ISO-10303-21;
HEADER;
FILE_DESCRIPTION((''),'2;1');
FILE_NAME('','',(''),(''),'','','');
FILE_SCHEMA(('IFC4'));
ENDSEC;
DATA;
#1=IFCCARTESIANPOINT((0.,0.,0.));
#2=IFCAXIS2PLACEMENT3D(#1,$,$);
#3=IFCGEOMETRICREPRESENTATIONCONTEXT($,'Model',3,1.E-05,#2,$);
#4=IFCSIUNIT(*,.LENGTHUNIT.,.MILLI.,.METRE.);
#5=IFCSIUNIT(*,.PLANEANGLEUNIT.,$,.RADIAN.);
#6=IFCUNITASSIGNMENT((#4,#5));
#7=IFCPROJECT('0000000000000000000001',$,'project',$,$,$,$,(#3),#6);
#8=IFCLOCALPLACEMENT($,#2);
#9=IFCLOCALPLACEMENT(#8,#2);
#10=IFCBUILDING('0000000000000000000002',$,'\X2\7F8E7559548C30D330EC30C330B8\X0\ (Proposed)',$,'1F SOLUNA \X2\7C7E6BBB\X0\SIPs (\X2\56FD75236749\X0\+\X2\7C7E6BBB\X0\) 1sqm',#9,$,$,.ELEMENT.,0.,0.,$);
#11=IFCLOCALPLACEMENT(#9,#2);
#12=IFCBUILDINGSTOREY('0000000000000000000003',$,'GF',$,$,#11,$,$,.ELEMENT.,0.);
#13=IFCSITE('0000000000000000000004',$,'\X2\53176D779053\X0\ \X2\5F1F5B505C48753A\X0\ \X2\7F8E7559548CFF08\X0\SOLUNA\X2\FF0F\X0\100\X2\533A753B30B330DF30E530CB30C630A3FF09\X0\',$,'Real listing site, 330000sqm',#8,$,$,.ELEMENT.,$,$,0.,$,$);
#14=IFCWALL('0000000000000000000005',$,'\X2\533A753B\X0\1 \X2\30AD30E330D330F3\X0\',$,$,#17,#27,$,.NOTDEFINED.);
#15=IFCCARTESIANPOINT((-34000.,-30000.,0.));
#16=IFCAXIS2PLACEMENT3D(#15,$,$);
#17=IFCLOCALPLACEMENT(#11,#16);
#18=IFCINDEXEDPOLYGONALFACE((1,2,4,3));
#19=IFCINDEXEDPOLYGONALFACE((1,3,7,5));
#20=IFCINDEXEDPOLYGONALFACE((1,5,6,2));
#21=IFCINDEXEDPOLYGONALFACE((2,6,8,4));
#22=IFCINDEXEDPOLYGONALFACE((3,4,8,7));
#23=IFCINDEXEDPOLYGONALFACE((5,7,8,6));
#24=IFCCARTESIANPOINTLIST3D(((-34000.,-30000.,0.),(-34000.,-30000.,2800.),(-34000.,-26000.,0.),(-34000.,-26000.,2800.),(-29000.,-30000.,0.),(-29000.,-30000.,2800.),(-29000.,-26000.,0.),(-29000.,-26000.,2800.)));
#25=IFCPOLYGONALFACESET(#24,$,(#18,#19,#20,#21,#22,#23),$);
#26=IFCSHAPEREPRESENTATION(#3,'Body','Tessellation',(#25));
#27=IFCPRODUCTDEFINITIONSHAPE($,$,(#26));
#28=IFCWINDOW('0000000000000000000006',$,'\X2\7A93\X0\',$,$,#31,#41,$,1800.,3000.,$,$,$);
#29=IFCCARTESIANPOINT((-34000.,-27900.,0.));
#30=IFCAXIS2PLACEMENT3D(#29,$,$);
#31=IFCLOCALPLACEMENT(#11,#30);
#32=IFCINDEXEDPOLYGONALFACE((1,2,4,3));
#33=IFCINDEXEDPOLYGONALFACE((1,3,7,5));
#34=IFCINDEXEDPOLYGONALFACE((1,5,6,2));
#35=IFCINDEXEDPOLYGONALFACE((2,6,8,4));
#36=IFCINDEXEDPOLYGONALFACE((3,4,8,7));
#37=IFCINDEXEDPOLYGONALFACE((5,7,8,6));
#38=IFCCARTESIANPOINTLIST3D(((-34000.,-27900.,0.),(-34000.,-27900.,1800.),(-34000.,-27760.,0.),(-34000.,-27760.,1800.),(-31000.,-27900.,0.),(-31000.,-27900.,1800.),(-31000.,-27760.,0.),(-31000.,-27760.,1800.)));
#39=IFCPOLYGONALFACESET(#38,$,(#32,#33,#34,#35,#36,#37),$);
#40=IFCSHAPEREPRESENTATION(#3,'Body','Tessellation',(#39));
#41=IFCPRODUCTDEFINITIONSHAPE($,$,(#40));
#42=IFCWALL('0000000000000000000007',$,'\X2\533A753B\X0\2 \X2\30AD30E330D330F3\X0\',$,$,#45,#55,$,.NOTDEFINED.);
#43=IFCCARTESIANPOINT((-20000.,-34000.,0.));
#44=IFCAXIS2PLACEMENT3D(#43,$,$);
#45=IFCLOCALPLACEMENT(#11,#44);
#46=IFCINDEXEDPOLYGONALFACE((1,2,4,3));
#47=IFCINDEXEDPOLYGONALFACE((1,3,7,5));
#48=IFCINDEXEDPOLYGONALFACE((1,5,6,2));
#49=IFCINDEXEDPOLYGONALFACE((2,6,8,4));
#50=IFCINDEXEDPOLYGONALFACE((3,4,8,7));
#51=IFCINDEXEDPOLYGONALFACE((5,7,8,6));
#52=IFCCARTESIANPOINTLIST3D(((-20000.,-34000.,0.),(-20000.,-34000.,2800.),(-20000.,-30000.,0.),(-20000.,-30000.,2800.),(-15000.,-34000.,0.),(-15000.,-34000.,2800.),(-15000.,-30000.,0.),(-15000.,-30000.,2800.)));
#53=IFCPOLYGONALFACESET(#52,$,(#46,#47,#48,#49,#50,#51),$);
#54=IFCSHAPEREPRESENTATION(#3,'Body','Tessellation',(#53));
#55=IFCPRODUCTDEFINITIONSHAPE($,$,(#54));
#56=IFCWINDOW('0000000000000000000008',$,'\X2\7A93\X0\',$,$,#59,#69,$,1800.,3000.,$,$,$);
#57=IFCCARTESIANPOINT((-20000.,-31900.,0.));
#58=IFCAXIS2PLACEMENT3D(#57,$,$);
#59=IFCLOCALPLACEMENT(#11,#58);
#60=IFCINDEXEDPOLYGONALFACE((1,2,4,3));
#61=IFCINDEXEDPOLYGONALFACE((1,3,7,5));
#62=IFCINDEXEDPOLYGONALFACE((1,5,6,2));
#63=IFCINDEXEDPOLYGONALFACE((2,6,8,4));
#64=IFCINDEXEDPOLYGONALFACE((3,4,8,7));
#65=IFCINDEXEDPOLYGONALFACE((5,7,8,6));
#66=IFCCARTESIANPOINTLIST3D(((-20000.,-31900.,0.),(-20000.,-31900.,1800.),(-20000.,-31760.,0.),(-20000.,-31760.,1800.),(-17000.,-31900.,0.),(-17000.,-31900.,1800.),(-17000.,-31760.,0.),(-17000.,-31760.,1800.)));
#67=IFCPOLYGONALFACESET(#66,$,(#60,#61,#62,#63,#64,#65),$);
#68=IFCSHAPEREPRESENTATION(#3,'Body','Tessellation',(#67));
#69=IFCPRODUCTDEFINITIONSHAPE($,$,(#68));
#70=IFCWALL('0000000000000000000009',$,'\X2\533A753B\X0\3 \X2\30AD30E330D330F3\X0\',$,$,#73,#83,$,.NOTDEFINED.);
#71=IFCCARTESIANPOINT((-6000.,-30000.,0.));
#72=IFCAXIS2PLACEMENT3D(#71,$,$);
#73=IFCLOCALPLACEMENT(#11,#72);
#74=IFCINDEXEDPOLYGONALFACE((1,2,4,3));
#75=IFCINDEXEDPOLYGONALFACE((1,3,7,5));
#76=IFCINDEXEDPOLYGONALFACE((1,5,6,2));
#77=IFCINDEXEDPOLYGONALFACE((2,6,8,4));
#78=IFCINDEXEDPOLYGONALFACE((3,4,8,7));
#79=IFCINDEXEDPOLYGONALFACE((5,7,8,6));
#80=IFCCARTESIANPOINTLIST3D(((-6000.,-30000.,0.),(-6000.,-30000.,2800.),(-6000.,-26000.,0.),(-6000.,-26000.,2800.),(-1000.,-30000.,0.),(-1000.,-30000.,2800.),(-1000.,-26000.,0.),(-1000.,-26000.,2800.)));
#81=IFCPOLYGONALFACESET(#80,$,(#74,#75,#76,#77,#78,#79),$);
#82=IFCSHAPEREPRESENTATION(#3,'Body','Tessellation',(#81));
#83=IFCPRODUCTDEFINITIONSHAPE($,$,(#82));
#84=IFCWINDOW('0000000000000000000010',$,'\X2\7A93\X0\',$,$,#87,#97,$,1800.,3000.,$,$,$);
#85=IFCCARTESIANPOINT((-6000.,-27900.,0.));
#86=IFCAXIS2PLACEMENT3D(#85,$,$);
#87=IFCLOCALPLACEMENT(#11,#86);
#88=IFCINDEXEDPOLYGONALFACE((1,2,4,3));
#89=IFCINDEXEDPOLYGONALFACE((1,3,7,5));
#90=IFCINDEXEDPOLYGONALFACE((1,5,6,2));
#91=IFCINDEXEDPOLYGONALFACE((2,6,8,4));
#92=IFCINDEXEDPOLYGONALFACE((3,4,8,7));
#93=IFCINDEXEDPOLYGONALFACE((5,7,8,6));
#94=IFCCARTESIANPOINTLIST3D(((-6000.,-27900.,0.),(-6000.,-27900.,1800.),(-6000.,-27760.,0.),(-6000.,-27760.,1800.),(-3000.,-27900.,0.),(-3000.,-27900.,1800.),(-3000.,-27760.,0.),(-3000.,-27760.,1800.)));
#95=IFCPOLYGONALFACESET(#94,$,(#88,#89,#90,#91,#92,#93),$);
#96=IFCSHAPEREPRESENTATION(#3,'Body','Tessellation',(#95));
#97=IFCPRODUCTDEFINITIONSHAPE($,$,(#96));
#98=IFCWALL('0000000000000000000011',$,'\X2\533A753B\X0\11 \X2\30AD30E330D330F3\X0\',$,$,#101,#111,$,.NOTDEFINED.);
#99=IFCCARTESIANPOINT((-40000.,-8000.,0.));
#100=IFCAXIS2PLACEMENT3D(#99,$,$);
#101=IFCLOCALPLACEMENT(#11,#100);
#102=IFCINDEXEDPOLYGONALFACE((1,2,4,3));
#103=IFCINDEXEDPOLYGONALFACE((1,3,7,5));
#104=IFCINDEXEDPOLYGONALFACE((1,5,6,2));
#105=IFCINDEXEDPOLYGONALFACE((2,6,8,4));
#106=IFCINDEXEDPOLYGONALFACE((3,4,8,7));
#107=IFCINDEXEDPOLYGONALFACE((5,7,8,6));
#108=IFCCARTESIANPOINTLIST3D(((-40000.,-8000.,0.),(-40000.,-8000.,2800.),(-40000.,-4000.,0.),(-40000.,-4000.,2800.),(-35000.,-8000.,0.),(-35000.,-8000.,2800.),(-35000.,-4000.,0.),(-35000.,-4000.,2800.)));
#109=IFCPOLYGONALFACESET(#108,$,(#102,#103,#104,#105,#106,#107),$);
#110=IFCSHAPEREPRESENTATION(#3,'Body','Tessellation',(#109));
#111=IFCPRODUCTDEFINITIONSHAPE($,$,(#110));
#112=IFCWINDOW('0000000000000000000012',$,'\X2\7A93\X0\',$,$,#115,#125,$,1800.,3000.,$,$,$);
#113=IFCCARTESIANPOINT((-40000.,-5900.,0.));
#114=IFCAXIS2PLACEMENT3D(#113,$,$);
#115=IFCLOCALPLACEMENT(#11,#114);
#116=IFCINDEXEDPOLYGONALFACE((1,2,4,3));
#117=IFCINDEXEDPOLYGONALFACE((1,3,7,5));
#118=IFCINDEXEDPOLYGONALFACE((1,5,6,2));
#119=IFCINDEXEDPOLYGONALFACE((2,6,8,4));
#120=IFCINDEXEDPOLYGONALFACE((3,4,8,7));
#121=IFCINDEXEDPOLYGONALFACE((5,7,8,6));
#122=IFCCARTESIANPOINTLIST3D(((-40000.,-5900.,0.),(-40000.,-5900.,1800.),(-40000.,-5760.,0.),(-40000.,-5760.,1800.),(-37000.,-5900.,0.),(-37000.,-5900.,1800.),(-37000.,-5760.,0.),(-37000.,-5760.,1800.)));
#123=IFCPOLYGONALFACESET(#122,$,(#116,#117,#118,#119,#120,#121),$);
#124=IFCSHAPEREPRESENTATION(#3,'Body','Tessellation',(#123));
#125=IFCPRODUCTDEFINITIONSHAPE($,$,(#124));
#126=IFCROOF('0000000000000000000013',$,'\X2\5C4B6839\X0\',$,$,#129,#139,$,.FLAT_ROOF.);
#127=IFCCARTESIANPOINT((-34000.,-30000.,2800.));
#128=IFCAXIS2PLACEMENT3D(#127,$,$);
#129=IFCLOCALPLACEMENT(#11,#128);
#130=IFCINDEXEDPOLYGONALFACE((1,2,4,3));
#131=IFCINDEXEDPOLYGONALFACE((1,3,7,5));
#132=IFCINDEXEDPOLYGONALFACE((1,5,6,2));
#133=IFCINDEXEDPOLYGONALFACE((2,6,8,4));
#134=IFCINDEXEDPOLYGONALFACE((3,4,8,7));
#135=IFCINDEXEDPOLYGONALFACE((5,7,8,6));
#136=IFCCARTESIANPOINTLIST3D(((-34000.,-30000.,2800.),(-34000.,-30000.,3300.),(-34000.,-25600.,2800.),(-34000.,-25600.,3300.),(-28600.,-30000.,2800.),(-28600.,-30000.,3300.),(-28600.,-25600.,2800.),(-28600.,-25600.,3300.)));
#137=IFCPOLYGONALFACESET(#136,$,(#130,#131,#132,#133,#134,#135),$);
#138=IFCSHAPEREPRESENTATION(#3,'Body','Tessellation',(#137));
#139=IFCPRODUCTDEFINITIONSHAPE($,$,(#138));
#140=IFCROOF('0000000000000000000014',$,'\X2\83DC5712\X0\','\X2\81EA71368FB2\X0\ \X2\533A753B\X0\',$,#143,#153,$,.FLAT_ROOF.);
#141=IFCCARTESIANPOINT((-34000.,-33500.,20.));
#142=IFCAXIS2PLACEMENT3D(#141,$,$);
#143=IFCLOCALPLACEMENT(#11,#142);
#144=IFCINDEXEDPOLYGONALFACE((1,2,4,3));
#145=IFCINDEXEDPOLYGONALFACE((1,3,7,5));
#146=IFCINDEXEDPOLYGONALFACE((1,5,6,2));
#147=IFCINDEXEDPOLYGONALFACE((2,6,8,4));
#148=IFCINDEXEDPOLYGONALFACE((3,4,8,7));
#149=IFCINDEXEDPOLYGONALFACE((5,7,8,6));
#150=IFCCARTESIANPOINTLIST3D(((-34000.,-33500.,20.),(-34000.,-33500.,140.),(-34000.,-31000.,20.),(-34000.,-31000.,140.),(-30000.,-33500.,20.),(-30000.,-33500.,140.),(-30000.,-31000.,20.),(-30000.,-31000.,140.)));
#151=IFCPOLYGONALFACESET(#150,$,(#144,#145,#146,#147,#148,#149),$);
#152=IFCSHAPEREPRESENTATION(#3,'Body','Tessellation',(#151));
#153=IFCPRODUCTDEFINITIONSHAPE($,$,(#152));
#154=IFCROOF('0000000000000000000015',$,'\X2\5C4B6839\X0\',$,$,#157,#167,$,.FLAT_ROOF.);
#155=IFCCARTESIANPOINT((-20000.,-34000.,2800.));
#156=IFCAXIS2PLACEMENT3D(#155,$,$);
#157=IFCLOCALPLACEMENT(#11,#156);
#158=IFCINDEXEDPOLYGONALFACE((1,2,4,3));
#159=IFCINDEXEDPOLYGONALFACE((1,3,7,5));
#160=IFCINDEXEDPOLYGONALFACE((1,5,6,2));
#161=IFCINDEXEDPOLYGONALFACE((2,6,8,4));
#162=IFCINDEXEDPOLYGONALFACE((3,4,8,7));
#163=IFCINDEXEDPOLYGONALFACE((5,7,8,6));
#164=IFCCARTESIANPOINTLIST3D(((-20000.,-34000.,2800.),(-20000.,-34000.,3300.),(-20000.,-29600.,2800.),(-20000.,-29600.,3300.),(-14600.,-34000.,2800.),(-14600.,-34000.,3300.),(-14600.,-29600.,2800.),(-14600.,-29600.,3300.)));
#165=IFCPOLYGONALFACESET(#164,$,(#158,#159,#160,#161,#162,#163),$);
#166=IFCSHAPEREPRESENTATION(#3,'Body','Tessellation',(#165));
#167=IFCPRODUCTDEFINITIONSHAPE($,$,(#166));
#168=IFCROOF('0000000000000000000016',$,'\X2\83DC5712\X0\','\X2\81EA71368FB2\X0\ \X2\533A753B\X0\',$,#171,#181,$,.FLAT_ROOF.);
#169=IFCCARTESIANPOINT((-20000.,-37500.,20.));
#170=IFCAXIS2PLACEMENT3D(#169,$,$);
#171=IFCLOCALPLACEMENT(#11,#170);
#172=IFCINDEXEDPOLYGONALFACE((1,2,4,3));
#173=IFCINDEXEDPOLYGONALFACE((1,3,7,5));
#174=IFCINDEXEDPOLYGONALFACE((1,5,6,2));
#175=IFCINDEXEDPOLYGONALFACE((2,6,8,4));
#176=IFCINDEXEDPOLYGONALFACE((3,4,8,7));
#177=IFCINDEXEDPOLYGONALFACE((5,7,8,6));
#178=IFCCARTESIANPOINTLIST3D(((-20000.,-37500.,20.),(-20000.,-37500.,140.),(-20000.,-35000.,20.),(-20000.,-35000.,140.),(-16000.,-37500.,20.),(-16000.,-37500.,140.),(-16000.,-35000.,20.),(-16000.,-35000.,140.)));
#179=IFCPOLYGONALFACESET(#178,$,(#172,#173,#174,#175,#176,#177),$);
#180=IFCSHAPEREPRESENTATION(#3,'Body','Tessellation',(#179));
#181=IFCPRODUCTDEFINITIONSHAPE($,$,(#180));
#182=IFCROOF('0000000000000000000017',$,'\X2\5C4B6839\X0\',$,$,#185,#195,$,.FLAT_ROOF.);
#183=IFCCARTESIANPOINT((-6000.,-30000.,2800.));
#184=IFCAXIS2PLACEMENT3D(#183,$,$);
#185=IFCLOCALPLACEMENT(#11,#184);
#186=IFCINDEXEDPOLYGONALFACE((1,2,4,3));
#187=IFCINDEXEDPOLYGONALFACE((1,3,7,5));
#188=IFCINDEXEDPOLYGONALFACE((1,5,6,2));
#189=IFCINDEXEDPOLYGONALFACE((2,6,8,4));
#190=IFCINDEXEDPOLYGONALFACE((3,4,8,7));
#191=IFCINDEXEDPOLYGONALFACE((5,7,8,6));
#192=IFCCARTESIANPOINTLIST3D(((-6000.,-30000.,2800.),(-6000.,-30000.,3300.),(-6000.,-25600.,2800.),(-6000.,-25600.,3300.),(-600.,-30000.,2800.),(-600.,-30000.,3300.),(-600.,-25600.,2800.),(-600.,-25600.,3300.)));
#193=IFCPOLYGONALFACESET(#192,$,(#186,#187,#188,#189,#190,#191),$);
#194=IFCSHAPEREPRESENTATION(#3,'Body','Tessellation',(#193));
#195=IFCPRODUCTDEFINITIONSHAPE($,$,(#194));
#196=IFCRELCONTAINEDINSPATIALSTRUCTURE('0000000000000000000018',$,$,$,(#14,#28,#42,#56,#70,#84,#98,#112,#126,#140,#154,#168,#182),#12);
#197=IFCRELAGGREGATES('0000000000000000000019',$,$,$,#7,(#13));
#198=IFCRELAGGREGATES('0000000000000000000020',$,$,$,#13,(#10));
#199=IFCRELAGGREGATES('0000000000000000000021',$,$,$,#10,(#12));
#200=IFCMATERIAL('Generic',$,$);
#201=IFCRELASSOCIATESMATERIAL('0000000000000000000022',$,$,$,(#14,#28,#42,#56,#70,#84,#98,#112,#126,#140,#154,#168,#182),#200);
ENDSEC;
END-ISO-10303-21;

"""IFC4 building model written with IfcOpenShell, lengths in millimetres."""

from ifc_helpers import new_model, si_unit, frame, frame_2d, origin, place, context, project, spatial, rectangle, extrude, material, element, fill, save


model = new_model("IFC4")

# Units and contexts
model_context = context("Model", 3, precision=1e-05, world=origin())
ifc_project = project(units=[si_unit("LENGTHUNIT", "METRE", prefix="MILLI"), si_unit("PLANEANGLEUNIT", "RADIAN")], contexts=[model_context])

# Site, building, storey
site_placement = place(None, origin())
site = spatial("IfcSite", under=ifc_project, at=site_placement, Name="北海道 弟子屈町 美留和（SOLUNA／100区画コミュニティ）", ObjectType="Real listing site, 330000sqm", CompositionType="ELEMENT", RefElevation=0.0)
building_placement = place(site_placement, origin())
building = spatial("IfcBuilding", under=site, at=building_placement, Name="美留和ビレッジ (Proposed)", ObjectType="1F SOLUNA 籾殻SIPs (国産杉+籾殻) 1sqm", CompositionType="ELEMENT", ElevationOfRefHeight=0.0, ElevationOfTerrain=0.0)
storey_placement = place(building_placement, origin())
storey = spatial("IfcBuildingStorey", under=building, at=storey_placement, Name="GF", CompositionType="ELEMENT", Elevation=0.0)

# Walls, openings, windows
ifc_material_1 = material(Name="Generic")
wall_1_placement = place(storey_placement, frame((-34000.0, -30000.0, 0.0)))
wall_1 = element("IfcWall", 1, at=wall_1_placement, inside=storey, material=ifc_material_1, Name="区画1 キャビン", PredefinedType="NOTDEFINED", context=model_context, shape_type="SweptSolid", body=[
    extrude(rectangle(XDim=5000.0, YDim=4000.0, at=frame_2d((2500.0, 2000.0))), frame((-34000.0, -30000.0, 0.0)), (0.0, 0.0, 1.0), 2800.0),
])
opening_1_placement = place(storey_placement, frame((-34000.0, -27900.0, 0.0)))
opening_1 = element("IfcOpeningElement", 2, at=opening_1_placement, cuts=wall_1, PredefinedType="NOTDEFINED", context=model_context, shape_type="SweptSolid", body=[
    extrude(rectangle(XDim=3000.0, YDim=140.0, at=frame_2d((1500.0, 70.0))), frame((-34000.0, -27900.0, 0.0)), (0.0, 0.0, 1.0), 1800.0),
])
window_1_placement = place(storey_placement, frame((-34000.0, -27900.0, 0.0)))
window_1 = element("IfcWindow", 3, at=window_1_placement, inside=storey, material=ifc_material_1, Name="窓", OverallHeight=1800.0, OverallWidth=3000.0, context=model_context, shape_type="SweptSolid", body=[
    extrude(rectangle(XDim=3000.0, YDim=140.0, at=frame_2d((1500.0, 70.0))), frame((-34000.0, -27900.0, 0.0)), (0.0, 0.0, 1.0), 1800.0),
])
fill(opening_1, window_1)
wall_2_placement = place(storey_placement, frame((-20000.0, -34000.0, 0.0)))
wall_2 = element("IfcWall", 4, at=wall_2_placement, inside=storey, material=ifc_material_1, Name="区画2 キャビン", PredefinedType="NOTDEFINED", context=model_context, shape_type="SweptSolid", body=[
    extrude(rectangle(XDim=5000.0, YDim=4000.0, at=frame_2d((2500.0, 2000.0))), frame((-20000.0, -34000.0, 0.0)), (0.0, 0.0, 1.0), 2800.0),
])
opening_2_placement = place(storey_placement, frame((-20000.0, -31900.0, 0.0)))
opening_2 = element("IfcOpeningElement", 5, at=opening_2_placement, cuts=wall_2, PredefinedType="NOTDEFINED", context=model_context, shape_type="SweptSolid", body=[
    extrude(rectangle(XDim=3000.0, YDim=140.0, at=frame_2d((1500.0, 70.0))), frame((-20000.0, -31900.0, 0.0)), (0.0, 0.0, 1.0), 1800.0),
])
window_2_placement = place(storey_placement, frame((-20000.0, -31900.0, 0.0)))
window_2 = element("IfcWindow", 6, at=window_2_placement, inside=storey, material=ifc_material_1, Name="窓", OverallHeight=1800.0, OverallWidth=3000.0, context=model_context, shape_type="SweptSolid", body=[
    extrude(rectangle(XDim=3000.0, YDim=140.0, at=frame_2d((1500.0, 70.0))), frame((-20000.0, -31900.0, 0.0)), (0.0, 0.0, 1.0), 1800.0),
])
fill(opening_2, window_2)
wall_3_placement = place(storey_placement, frame((-6000.0, -30000.0, 0.0)))
wall_3 = element("IfcWall", 7, at=wall_3_placement, inside=storey, material=ifc_material_1, Name="区画3 キャビン", PredefinedType="NOTDEFINED", context=model_context, shape_type="SweptSolid", body=[
    extrude(rectangle(XDim=5000.0, YDim=4000.0, at=frame_2d((2500.0, 2000.0))), frame((-6000.0, -30000.0, 0.0)), (0.0, 0.0, 1.0), 2800.0),
])
opening_3_placement = place(storey_placement, frame((-6000.0, -27900.0, 0.0)))
opening_3 = element("IfcOpeningElement", 8, at=opening_3_placement, cuts=wall_3, PredefinedType="NOTDEFINED", context=model_context, shape_type="SweptSolid", body=[
    extrude(rectangle(XDim=3000.0, YDim=140.0, at=frame_2d((1500.0, 70.0))), frame((-6000.0, -27900.0, 0.0)), (0.0, 0.0, 1.0), 1800.0),
])
window_3_placement = place(storey_placement, frame((-6000.0, -27900.0, 0.0)))
window_3 = element("IfcWindow", 9, at=window_3_placement, inside=storey, material=ifc_material_1, Name="窓", OverallHeight=1800.0, OverallWidth=3000.0, context=model_context, shape_type="SweptSolid", body=[
    extrude(rectangle(XDim=3000.0, YDim=140.0, at=frame_2d((1500.0, 70.0))), frame((-6000.0, -27900.0, 0.0)), (0.0, 0.0, 1.0), 1800.0),
])
fill(opening_3, window_3)
wall_4_placement = place(storey_placement, frame((-40000.0, -8000.0, 0.0)))
wall_4 = element("IfcWall", 10, at=wall_4_placement, inside=storey, material=ifc_material_1, Name="区画11 キャビン", PredefinedType="NOTDEFINED", context=model_context, shape_type="SweptSolid", body=[
    extrude(rectangle(XDim=5000.0, YDim=4000.0, at=frame_2d((2500.0, 2000.0))), frame((-40000.0, -8000.0, 0.0)), (0.0, 0.0, 1.0), 2800.0),
])
opening_4_placement = place(storey_placement, frame((-40000.0, -5900.0, 0.0)))
opening_4 = element("IfcOpeningElement", 11, at=opening_4_placement, cuts=wall_4, PredefinedType="NOTDEFINED", context=model_context, shape_type="SweptSolid", body=[
    extrude(rectangle(XDim=3000.0, YDim=140.0, at=frame_2d((1500.0, 70.0))), frame((-40000.0, -5900.0, 0.0)), (0.0, 0.0, 1.0), 1800.0),
])
window_4_placement = place(storey_placement, frame((-40000.0, -5900.0, 0.0)))
window_4 = element("IfcWindow", 12, at=window_4_placement, inside=storey, material=ifc_material_1, Name="窓", OverallHeight=1800.0, OverallWidth=3000.0, context=model_context, shape_type="SweptSolid", body=[
    extrude(rectangle(XDim=3000.0, YDim=140.0, at=frame_2d((1500.0, 70.0))), frame((-40000.0, -5900.0, 0.0)), (0.0, 0.0, 1.0), 1800.0),
])
fill(opening_4, window_4)

# Roofs
roof_1_placement = place(storey_placement, frame((-34000.0, -30000.0, 2800.0)))
element("IfcRoof", 13, at=roof_1_placement, inside=storey, material=ifc_material_1, Name="屋根", PredefinedType="FLAT_ROOF", context=model_context, shape_type="SweptSolid", body=[
    extrude(rectangle(XDim=5400.0, YDim=4400.0, at=frame_2d((2700.0, 2200.0))), frame((-34000.0, -30000.0, 2800.0)), (0.0, 0.0, 1.0), 500.0),
])
roof_2_placement = place(storey_placement, frame((-34000.0, -33500.0, 20.0)))
element("IfcRoof", 14, at=roof_2_placement, inside=storey, material=ifc_material_1, Name="菜園", Description="自然農 区画", PredefinedType="FLAT_ROOF", context=model_context, shape_type="SweptSolid", body=[
    extrude(rectangle(XDim=4000.0, YDim=2500.0, at=frame_2d((2000.0, 1250.0))), frame((-34000.0, -33500.0, 20.0)), (0.0, 0.0, 1.0), 120.0),
])
roof_3_placement = place(storey_placement, frame((-20000.0, -34000.0, 2800.0)))
element("IfcRoof", 15, at=roof_3_placement, inside=storey, material=ifc_material_1, Name="屋根", PredefinedType="FLAT_ROOF", context=model_context, shape_type="SweptSolid", body=[
    extrude(rectangle(XDim=5400.0, YDim=4400.0, at=frame_2d((2700.0, 2200.0))), frame((-20000.0, -34000.0, 2800.0)), (0.0, 0.0, 1.0), 500.0),
])
roof_4_placement = place(storey_placement, frame((-20000.0, -37500.0, 20.0)))
element("IfcRoof", 16, at=roof_4_placement, inside=storey, material=ifc_material_1, Name="菜園", Description="自然農 区画", PredefinedType="FLAT_ROOF", context=model_context, shape_type="SweptSolid", body=[
    extrude(rectangle(XDim=4000.0, YDim=2500.0, at=frame_2d((2000.0, 1250.0))), frame((-20000.0, -37500.0, 20.0)), (0.0, 0.0, 1.0), 120.0),
])
roof_5_placement = place(storey_placement, frame((-6000.0, -30000.0, 2800.0)))
element("IfcRoof", 17, at=roof_5_placement, inside=storey, material=ifc_material_1, Name="屋根", PredefinedType="FLAT_ROOF", context=model_context, shape_type="SweptSolid", body=[
    extrude(rectangle(XDim=5400.0, YDim=4400.0, at=frame_2d((2700.0, 2200.0))), frame((-6000.0, -30000.0, 2800.0)), (0.0, 0.0, 1.0), 500.0),
])

save(model, "model.ifc")
